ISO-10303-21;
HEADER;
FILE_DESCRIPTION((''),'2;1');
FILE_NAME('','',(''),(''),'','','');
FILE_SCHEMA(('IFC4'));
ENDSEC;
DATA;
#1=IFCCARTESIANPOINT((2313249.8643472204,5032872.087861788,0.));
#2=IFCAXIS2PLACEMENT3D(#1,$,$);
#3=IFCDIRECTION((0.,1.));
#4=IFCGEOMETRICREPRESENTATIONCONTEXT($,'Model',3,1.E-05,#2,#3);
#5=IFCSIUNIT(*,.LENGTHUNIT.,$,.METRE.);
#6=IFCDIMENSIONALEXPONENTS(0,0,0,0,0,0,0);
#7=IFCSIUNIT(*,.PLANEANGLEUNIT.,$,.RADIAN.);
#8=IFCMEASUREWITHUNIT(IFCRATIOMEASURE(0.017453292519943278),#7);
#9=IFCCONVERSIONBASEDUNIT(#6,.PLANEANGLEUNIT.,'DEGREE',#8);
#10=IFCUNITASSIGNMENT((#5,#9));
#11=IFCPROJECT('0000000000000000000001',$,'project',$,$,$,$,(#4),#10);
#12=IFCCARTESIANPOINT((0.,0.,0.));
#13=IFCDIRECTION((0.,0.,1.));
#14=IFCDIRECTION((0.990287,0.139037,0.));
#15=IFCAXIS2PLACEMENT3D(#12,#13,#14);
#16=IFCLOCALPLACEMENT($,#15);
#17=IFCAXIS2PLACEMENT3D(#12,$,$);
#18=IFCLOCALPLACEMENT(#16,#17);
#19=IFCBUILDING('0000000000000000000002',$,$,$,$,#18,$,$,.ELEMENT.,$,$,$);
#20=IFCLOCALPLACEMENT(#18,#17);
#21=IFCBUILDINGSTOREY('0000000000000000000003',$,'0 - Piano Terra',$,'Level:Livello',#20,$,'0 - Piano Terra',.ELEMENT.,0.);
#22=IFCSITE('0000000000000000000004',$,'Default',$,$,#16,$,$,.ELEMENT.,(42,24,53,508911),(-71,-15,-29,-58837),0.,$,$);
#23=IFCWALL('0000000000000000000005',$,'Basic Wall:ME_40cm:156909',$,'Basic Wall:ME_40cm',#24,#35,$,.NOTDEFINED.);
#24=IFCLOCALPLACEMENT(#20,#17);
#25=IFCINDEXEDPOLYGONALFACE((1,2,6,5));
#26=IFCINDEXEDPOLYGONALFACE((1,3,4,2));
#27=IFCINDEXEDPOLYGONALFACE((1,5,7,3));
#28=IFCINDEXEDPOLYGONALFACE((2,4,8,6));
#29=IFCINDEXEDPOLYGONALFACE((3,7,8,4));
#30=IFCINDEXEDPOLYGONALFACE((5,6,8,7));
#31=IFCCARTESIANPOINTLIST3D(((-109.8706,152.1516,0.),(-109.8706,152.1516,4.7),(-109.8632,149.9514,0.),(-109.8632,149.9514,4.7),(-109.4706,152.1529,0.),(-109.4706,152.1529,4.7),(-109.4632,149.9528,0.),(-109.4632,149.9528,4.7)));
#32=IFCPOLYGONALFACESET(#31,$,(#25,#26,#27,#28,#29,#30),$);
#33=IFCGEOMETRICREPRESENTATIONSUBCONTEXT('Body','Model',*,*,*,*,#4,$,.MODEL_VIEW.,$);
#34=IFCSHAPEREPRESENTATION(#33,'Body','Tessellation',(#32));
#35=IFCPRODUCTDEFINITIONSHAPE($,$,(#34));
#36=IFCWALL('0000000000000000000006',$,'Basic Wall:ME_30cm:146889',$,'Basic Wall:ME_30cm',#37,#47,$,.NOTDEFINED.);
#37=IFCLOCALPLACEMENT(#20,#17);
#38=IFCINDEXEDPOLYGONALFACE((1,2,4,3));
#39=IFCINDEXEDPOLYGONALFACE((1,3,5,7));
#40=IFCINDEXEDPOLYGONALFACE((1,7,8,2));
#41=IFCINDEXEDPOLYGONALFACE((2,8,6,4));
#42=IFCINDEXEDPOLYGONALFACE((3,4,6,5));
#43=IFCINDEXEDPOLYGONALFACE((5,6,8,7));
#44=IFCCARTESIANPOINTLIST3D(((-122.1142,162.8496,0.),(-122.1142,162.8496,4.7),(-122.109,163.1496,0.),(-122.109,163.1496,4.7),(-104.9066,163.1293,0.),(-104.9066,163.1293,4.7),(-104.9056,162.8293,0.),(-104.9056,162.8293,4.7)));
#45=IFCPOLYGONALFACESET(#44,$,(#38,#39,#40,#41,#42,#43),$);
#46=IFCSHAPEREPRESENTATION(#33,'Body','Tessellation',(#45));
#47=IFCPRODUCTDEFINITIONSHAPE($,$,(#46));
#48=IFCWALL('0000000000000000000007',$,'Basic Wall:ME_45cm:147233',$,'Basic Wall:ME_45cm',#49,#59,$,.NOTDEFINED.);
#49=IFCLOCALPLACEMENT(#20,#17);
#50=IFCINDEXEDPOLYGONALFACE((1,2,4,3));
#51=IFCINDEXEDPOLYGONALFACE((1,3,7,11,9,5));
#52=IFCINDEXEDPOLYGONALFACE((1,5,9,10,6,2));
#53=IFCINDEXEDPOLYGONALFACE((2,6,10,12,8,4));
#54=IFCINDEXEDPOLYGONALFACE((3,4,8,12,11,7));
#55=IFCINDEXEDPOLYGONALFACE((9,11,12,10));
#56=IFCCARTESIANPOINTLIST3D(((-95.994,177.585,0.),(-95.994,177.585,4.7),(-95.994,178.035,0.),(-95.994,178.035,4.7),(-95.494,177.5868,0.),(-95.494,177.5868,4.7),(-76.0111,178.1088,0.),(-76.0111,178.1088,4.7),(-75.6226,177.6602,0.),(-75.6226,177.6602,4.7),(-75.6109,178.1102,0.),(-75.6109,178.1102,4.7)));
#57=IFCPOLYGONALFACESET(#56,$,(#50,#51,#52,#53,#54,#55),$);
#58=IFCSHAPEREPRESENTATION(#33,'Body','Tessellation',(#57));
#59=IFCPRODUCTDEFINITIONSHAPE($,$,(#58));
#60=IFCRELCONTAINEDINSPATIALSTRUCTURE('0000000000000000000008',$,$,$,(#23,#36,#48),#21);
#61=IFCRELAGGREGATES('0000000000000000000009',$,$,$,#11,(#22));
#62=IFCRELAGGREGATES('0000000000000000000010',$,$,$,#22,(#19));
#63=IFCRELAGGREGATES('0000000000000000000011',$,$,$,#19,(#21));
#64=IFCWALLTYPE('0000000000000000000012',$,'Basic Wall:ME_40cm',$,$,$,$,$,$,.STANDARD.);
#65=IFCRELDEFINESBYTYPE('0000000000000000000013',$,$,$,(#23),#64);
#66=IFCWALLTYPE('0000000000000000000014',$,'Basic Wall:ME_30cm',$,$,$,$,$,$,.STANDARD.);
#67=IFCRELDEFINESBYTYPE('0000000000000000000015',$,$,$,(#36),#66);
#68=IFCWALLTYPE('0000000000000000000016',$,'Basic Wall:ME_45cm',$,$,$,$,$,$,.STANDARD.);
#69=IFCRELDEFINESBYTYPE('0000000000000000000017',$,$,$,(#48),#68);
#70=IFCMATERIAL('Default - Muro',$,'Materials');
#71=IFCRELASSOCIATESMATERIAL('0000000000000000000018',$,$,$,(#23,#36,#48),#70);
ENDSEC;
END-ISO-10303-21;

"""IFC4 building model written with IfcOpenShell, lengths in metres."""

from ifc_helpers import new_model, entity, si_unit, converted_unit, direction, frame, origin, place, context, subcontext, project, spatial, indexed_curve, outline, extrude, material, type_object, element, save


model = new_model("IFC4")

# Units and contexts
model_context = context("Model", 3, precision=1e-05, world=frame((2313249.8643472204, 5032872.087861788, 0.0)), true_north=direction((0.0, 1.0)))
body_context = subcontext(model_context, "Body", "Model", "MODEL_VIEW")
ifc_project = project(units=[si_unit("LENGTHUNIT", "METRE"), converted_unit("PLANEANGLEUNIT", "DEGREE", entity("IfcRatioMeasure", 0.017453292519943278), si_unit("PLANEANGLEUNIT", "RADIAN"), dimensions=[0, 0, 0, 0, 0, 0, 0])], contexts=[model_context])

# Site, building, storey
site_placement = place(None, frame((0.0, 0.0, 0.0), z_axis=(0.0, 0.0, 1.0), x_axis=(0.990287, 0.139037, 0.0)))
site = spatial("IfcSite", under=ifc_project, at=site_placement, Name="Default", CompositionType="ELEMENT", RefLatitude=(42, 24, 53, 508911), RefLongitude=(-71, -15, -29, -58837), RefElevation=0.0)
building_placement = place(site_placement, origin())
building = spatial("IfcBuilding", under=site, at=building_placement, CompositionType="ELEMENT")
storey_placement = place(building_placement, origin())
storey = spatial("IfcBuildingStorey", under=building, at=storey_placement, Name="0 - Piano Terra", ObjectType="Level:Livello", LongName="0 - Piano Terra", CompositionType="ELEMENT", Elevation=0.0)

# Walls
ifc_material = material(Name="Default - Muro", Category="Materials")
wall_type_1 = type_object("IfcWallType", Name="Basic Wall:ME_40cm", PredefinedType="STANDARD")
wall_1_placement = place(storey_placement, frame((-109.6632, 149.9521, 0.0), z_axis=(0.0, 0.0, 1.0), x_axis=(-0.003356, 0.999994, 0.0)))
element("IfcWall", 1, at=wall_1_placement, inside=storey, type_object=wall_type_1, material=ifc_material, Name="Basic Wall:ME_40cm:156909", ObjectType="Basic Wall:ME_40cm", PredefinedType="NOTDEFINED", context=body_context, shape_type="SweptSolid", body=[
    extrude(outline(indexed_curve([(2.2002, 0.2), (0.0, 0.2), (0.0, -0.2), (2.2002, -0.2), (2.2002, 0.2)], self_intersect=False)), origin(), (0.0, 0.0, 1.0), 4.7),
])
wall_type_2 = type_object("IfcWallType", Name="Basic Wall:ME_30cm", PredefinedType="STANDARD")
wall_2_placement = place(storey_placement, frame((-122.114, 162.9996, 0.0), z_axis=(0.0, 0.0, 1.0), x_axis=(0.999999, -0.001178, 0.0)))
element("IfcWall", 2, at=wall_2_placement, inside=storey, type_object=wall_type_2, material=ifc_material, Name="Basic Wall:ME_30cm:146889", ObjectType="Basic Wall:ME_30cm", PredefinedType="NOTDEFINED", context=body_context, shape_type="SweptSolid", body=[
    extrude(outline(indexed_curve([(17.2086, -0.15), (17.2073, 0.15), (0.0049, 0.15), (0.0, -0.15), (17.2086, -0.15)], self_intersect=False)), origin(), (0.0, 0.0, 1.0), 4.7),
])
wall_type_3 = type_object("IfcWallType", Name="Basic Wall:ME_45cm", PredefinedType="STANDARD")
wall_3_placement = place(storey_placement, frame((-75.6101, 177.8852, 0.0), z_axis=(0.0, 0.0, 1.0), x_axis=(-0.999993, -0.003692, 0.0)))
element("IfcWall", 3, at=wall_3_placement, inside=storey, type_object=wall_type_3, material=ifc_material, Name="Basic Wall:ME_45cm:147233", ObjectType="Basic Wall:ME_45cm", PredefinedType="NOTDEFINED", context=body_context, shape_type="SweptSolid", body=[
    extrude(outline(indexed_curve([(20.3832, -0.225), (20.3849, 0.225), (19.8849, 0.225), (0.0133, 0.225), (0.0, -0.225), (0.4002, -0.225), (20.3832, -0.225)], self_intersect=False)), origin(), (0.0, 0.0, 1.0), 4.7),
])

save(model, "model.ifc")
